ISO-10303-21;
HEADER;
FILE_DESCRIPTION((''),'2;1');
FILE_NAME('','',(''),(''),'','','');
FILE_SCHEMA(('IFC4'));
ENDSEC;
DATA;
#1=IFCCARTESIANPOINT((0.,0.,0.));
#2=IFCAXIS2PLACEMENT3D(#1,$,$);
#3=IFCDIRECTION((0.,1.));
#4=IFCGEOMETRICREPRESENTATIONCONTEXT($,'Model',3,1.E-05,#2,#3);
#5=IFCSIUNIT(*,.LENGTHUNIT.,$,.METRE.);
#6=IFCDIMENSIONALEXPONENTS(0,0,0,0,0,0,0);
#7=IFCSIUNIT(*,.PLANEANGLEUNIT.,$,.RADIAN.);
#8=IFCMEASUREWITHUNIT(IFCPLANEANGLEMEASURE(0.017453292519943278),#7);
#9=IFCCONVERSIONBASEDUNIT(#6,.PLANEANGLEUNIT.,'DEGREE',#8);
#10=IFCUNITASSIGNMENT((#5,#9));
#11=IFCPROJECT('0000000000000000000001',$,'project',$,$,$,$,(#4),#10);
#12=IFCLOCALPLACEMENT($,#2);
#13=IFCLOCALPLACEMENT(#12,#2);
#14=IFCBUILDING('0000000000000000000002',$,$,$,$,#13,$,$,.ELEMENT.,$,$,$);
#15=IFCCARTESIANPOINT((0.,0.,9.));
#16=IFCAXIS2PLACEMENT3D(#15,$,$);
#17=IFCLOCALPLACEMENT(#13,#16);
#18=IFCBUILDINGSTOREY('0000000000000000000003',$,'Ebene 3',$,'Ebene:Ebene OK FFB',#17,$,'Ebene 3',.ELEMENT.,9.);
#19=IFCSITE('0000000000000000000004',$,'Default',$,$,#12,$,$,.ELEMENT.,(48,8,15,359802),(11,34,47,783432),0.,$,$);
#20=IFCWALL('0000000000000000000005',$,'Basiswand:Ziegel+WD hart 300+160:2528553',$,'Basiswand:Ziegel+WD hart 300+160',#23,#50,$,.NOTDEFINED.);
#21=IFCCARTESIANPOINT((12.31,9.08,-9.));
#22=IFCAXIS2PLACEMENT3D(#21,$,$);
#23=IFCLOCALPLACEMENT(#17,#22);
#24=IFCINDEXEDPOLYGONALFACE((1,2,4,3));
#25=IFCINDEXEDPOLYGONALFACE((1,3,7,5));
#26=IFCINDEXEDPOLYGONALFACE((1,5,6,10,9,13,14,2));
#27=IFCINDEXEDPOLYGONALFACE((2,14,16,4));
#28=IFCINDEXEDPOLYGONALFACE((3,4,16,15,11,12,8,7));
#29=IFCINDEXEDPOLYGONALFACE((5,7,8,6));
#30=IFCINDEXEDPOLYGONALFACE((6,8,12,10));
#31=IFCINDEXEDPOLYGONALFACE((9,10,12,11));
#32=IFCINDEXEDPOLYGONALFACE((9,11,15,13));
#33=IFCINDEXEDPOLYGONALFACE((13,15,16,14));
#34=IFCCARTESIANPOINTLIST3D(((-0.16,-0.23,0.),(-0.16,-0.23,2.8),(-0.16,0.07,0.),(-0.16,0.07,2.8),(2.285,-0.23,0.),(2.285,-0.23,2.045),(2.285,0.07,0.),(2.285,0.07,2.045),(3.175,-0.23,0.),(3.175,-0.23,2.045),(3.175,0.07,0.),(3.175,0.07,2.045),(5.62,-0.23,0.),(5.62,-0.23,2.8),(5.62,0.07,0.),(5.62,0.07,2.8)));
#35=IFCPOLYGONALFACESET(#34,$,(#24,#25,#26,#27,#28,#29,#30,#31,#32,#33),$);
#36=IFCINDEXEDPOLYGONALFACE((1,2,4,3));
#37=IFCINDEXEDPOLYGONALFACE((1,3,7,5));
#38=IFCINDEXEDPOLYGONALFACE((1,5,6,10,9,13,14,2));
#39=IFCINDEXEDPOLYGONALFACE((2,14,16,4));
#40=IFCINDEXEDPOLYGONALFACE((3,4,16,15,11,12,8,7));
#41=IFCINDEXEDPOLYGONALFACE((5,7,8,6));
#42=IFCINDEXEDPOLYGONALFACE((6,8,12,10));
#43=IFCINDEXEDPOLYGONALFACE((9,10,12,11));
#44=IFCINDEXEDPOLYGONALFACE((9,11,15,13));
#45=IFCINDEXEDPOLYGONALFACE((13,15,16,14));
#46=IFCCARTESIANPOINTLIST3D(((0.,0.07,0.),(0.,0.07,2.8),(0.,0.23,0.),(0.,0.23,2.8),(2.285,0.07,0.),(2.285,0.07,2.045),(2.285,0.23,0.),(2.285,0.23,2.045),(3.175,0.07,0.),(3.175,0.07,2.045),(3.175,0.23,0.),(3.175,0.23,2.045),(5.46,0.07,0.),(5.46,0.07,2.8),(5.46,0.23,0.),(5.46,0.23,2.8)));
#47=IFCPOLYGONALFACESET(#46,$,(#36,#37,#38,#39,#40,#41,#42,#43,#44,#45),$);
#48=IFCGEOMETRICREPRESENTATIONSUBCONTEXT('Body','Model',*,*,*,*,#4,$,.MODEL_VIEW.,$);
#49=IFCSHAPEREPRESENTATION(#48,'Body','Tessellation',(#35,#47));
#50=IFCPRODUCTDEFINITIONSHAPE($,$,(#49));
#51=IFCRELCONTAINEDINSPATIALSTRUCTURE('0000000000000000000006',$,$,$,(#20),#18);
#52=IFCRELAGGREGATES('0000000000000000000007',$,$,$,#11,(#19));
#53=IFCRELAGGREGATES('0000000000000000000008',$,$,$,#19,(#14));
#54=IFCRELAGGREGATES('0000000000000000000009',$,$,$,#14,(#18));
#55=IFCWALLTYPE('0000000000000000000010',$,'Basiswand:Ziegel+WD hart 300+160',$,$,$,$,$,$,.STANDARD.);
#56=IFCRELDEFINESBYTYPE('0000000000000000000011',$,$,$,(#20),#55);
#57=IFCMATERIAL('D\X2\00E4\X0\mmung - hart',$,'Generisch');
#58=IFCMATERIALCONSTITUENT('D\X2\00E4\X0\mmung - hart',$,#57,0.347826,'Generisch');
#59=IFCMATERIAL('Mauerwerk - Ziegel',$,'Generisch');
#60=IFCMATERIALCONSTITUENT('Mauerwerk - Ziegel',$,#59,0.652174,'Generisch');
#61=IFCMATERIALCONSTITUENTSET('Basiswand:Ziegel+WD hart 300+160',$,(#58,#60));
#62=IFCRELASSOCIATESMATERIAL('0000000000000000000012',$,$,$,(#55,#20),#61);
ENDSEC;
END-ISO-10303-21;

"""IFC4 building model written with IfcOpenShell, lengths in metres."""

from ifc_helpers import new_model, entity, si_unit, converted_unit, direction, frame, origin, place, context, subcontext, project, spatial, indexed_curve, outline, extrude, material, constituent, constituent_set, type_object, element, save


model = new_model("IFC4")

# Units and contexts
model_context = context("Model", 3, precision=1e-05, world=origin(), true_north=direction((0.0, 1.0)))
body_context = subcontext(model_context, "Body", "Model", "MODEL_VIEW")
ifc_project = project(units=[si_unit("LENGTHUNIT", "METRE"), converted_unit("PLANEANGLEUNIT", "DEGREE", entity("IfcPlaneAngleMeasure", 0.017453292519943278), si_unit("PLANEANGLEUNIT", "RADIAN"), dimensions=[0, 0, 0, 0, 0, 0, 0])], contexts=[model_context])

# Site, building, storey
site_placement = place(None, origin())
site = spatial("IfcSite", under=ifc_project, at=site_placement, Name="Default", CompositionType="ELEMENT", RefLatitude=(48, 8, 15, 359802), RefLongitude=(11, 34, 47, 783432), RefElevation=0.0)
building_placement = place(site_placement, origin())
building = spatial("IfcBuilding", under=site, at=building_placement, CompositionType="ELEMENT")
storey_placement = place(building_placement, frame((0.0, 0.0, 9.0)))
storey = spatial("IfcBuildingStorey", under=building, at=storey_placement, Name="Ebene 3", ObjectType="Ebene:Ebene OK FFB", LongName="Ebene 3", CompositionType="ELEMENT", Elevation=9.0)

# Shared definitions
ifc_material_1 = material(Name="Dämmung - hart", Category="Generisch")
ifc_constituent_1 = constituent(ifc_material_1, Name="Dämmung - hart", Category="Generisch", fraction=0.347826)
ifc_material_2 = material(Name="Mauerwerk - Ziegel", Category="Generisch")
ifc_constituent_2 = constituent(ifc_material_2, Name="Mauerwerk - Ziegel", Category="Generisch", fraction=0.652174)
ifc_constituent_set_1 = constituent_set(constituents=[ifc_constituent_1, ifc_constituent_2], Name="Basiswand:Ziegel+WD hart 300+160")
wall_type_1 = type_object("IfcWallType", Name="Basiswand:Ziegel+WD hart 300+160", PredefinedType="STANDARD", material=ifc_constituent_set_1)

# Wall, opening
wall_1_placement = place(storey_placement, frame((12.31, 9.08, -9.0)))
wall_1 = element("IfcWall", 1, at=wall_1_placement, inside=storey, type_object=wall_type_1, material=ifc_constituent_set_1, Name="Basiswand:Ziegel+WD hart 300+160:2528553", ObjectType="Basiswand:Ziegel+WD hart 300+160", PredefinedType="NOTDEFINED", context=body_context, shape_type="SweptSolid", body=[
    extrude(outline(indexed_curve([(-2.89, -1.5888), (2.89, -1.5888), (2.89, 1.2112), (0.445, 1.2112), (0.445, -0.8337), (-0.445, -0.8337), (-0.445, 1.2112), (-2.89, 1.2112), (-2.89, -1.5888)], self_intersect=False)), frame((2.73, -0.23, 1.2112), z_axis=(0.0, 1.0, 0.0), x_axis=(1.0, 0.0, 0.0)), (0.0, 0.0, 1.0), 0.3),
    extrude(outline(indexed_curve([(-1.2112, -0.445), (-1.2112, -2.73), (1.5888, -2.73), (1.5888, 2.73), (-1.2112, 2.73), (-1.2112, 0.445), (0.8337, 0.445), (0.8337, -0.445), (-1.2112, -0.445)], self_intersect=False)), frame((2.73, 0.07, 1.2112), z_axis=(0.0, -1.0, 0.0), x_axis=(0.0, 0.0, 1.0)), (0.0, 0.0, -1.0), 0.16),
])
opening_1_placement = place(wall_1_placement, frame((3.175, 0.23, -0.18)))
element("IfcOpeningElement", 2, at=opening_1_placement, cuts=wall_1, PredefinedType="OPENING", context=body_context, shape_type="SweptSolid", body=[
    extrude(outline(indexed_curve([(2.225, 0.89), (0.0, 0.89), (0.0, 0.0), (2.225, 0.0), (2.225, 0.89)], self_intersect=False)), frame((0.0, 0.0, 0.0), z_axis=(0.0, -1.0, 0.0), x_axis=(0.0, 0.0, 1.0)), (0.0, 0.0, 1.0), 0.46),
])

save(model, "model.ifc")
